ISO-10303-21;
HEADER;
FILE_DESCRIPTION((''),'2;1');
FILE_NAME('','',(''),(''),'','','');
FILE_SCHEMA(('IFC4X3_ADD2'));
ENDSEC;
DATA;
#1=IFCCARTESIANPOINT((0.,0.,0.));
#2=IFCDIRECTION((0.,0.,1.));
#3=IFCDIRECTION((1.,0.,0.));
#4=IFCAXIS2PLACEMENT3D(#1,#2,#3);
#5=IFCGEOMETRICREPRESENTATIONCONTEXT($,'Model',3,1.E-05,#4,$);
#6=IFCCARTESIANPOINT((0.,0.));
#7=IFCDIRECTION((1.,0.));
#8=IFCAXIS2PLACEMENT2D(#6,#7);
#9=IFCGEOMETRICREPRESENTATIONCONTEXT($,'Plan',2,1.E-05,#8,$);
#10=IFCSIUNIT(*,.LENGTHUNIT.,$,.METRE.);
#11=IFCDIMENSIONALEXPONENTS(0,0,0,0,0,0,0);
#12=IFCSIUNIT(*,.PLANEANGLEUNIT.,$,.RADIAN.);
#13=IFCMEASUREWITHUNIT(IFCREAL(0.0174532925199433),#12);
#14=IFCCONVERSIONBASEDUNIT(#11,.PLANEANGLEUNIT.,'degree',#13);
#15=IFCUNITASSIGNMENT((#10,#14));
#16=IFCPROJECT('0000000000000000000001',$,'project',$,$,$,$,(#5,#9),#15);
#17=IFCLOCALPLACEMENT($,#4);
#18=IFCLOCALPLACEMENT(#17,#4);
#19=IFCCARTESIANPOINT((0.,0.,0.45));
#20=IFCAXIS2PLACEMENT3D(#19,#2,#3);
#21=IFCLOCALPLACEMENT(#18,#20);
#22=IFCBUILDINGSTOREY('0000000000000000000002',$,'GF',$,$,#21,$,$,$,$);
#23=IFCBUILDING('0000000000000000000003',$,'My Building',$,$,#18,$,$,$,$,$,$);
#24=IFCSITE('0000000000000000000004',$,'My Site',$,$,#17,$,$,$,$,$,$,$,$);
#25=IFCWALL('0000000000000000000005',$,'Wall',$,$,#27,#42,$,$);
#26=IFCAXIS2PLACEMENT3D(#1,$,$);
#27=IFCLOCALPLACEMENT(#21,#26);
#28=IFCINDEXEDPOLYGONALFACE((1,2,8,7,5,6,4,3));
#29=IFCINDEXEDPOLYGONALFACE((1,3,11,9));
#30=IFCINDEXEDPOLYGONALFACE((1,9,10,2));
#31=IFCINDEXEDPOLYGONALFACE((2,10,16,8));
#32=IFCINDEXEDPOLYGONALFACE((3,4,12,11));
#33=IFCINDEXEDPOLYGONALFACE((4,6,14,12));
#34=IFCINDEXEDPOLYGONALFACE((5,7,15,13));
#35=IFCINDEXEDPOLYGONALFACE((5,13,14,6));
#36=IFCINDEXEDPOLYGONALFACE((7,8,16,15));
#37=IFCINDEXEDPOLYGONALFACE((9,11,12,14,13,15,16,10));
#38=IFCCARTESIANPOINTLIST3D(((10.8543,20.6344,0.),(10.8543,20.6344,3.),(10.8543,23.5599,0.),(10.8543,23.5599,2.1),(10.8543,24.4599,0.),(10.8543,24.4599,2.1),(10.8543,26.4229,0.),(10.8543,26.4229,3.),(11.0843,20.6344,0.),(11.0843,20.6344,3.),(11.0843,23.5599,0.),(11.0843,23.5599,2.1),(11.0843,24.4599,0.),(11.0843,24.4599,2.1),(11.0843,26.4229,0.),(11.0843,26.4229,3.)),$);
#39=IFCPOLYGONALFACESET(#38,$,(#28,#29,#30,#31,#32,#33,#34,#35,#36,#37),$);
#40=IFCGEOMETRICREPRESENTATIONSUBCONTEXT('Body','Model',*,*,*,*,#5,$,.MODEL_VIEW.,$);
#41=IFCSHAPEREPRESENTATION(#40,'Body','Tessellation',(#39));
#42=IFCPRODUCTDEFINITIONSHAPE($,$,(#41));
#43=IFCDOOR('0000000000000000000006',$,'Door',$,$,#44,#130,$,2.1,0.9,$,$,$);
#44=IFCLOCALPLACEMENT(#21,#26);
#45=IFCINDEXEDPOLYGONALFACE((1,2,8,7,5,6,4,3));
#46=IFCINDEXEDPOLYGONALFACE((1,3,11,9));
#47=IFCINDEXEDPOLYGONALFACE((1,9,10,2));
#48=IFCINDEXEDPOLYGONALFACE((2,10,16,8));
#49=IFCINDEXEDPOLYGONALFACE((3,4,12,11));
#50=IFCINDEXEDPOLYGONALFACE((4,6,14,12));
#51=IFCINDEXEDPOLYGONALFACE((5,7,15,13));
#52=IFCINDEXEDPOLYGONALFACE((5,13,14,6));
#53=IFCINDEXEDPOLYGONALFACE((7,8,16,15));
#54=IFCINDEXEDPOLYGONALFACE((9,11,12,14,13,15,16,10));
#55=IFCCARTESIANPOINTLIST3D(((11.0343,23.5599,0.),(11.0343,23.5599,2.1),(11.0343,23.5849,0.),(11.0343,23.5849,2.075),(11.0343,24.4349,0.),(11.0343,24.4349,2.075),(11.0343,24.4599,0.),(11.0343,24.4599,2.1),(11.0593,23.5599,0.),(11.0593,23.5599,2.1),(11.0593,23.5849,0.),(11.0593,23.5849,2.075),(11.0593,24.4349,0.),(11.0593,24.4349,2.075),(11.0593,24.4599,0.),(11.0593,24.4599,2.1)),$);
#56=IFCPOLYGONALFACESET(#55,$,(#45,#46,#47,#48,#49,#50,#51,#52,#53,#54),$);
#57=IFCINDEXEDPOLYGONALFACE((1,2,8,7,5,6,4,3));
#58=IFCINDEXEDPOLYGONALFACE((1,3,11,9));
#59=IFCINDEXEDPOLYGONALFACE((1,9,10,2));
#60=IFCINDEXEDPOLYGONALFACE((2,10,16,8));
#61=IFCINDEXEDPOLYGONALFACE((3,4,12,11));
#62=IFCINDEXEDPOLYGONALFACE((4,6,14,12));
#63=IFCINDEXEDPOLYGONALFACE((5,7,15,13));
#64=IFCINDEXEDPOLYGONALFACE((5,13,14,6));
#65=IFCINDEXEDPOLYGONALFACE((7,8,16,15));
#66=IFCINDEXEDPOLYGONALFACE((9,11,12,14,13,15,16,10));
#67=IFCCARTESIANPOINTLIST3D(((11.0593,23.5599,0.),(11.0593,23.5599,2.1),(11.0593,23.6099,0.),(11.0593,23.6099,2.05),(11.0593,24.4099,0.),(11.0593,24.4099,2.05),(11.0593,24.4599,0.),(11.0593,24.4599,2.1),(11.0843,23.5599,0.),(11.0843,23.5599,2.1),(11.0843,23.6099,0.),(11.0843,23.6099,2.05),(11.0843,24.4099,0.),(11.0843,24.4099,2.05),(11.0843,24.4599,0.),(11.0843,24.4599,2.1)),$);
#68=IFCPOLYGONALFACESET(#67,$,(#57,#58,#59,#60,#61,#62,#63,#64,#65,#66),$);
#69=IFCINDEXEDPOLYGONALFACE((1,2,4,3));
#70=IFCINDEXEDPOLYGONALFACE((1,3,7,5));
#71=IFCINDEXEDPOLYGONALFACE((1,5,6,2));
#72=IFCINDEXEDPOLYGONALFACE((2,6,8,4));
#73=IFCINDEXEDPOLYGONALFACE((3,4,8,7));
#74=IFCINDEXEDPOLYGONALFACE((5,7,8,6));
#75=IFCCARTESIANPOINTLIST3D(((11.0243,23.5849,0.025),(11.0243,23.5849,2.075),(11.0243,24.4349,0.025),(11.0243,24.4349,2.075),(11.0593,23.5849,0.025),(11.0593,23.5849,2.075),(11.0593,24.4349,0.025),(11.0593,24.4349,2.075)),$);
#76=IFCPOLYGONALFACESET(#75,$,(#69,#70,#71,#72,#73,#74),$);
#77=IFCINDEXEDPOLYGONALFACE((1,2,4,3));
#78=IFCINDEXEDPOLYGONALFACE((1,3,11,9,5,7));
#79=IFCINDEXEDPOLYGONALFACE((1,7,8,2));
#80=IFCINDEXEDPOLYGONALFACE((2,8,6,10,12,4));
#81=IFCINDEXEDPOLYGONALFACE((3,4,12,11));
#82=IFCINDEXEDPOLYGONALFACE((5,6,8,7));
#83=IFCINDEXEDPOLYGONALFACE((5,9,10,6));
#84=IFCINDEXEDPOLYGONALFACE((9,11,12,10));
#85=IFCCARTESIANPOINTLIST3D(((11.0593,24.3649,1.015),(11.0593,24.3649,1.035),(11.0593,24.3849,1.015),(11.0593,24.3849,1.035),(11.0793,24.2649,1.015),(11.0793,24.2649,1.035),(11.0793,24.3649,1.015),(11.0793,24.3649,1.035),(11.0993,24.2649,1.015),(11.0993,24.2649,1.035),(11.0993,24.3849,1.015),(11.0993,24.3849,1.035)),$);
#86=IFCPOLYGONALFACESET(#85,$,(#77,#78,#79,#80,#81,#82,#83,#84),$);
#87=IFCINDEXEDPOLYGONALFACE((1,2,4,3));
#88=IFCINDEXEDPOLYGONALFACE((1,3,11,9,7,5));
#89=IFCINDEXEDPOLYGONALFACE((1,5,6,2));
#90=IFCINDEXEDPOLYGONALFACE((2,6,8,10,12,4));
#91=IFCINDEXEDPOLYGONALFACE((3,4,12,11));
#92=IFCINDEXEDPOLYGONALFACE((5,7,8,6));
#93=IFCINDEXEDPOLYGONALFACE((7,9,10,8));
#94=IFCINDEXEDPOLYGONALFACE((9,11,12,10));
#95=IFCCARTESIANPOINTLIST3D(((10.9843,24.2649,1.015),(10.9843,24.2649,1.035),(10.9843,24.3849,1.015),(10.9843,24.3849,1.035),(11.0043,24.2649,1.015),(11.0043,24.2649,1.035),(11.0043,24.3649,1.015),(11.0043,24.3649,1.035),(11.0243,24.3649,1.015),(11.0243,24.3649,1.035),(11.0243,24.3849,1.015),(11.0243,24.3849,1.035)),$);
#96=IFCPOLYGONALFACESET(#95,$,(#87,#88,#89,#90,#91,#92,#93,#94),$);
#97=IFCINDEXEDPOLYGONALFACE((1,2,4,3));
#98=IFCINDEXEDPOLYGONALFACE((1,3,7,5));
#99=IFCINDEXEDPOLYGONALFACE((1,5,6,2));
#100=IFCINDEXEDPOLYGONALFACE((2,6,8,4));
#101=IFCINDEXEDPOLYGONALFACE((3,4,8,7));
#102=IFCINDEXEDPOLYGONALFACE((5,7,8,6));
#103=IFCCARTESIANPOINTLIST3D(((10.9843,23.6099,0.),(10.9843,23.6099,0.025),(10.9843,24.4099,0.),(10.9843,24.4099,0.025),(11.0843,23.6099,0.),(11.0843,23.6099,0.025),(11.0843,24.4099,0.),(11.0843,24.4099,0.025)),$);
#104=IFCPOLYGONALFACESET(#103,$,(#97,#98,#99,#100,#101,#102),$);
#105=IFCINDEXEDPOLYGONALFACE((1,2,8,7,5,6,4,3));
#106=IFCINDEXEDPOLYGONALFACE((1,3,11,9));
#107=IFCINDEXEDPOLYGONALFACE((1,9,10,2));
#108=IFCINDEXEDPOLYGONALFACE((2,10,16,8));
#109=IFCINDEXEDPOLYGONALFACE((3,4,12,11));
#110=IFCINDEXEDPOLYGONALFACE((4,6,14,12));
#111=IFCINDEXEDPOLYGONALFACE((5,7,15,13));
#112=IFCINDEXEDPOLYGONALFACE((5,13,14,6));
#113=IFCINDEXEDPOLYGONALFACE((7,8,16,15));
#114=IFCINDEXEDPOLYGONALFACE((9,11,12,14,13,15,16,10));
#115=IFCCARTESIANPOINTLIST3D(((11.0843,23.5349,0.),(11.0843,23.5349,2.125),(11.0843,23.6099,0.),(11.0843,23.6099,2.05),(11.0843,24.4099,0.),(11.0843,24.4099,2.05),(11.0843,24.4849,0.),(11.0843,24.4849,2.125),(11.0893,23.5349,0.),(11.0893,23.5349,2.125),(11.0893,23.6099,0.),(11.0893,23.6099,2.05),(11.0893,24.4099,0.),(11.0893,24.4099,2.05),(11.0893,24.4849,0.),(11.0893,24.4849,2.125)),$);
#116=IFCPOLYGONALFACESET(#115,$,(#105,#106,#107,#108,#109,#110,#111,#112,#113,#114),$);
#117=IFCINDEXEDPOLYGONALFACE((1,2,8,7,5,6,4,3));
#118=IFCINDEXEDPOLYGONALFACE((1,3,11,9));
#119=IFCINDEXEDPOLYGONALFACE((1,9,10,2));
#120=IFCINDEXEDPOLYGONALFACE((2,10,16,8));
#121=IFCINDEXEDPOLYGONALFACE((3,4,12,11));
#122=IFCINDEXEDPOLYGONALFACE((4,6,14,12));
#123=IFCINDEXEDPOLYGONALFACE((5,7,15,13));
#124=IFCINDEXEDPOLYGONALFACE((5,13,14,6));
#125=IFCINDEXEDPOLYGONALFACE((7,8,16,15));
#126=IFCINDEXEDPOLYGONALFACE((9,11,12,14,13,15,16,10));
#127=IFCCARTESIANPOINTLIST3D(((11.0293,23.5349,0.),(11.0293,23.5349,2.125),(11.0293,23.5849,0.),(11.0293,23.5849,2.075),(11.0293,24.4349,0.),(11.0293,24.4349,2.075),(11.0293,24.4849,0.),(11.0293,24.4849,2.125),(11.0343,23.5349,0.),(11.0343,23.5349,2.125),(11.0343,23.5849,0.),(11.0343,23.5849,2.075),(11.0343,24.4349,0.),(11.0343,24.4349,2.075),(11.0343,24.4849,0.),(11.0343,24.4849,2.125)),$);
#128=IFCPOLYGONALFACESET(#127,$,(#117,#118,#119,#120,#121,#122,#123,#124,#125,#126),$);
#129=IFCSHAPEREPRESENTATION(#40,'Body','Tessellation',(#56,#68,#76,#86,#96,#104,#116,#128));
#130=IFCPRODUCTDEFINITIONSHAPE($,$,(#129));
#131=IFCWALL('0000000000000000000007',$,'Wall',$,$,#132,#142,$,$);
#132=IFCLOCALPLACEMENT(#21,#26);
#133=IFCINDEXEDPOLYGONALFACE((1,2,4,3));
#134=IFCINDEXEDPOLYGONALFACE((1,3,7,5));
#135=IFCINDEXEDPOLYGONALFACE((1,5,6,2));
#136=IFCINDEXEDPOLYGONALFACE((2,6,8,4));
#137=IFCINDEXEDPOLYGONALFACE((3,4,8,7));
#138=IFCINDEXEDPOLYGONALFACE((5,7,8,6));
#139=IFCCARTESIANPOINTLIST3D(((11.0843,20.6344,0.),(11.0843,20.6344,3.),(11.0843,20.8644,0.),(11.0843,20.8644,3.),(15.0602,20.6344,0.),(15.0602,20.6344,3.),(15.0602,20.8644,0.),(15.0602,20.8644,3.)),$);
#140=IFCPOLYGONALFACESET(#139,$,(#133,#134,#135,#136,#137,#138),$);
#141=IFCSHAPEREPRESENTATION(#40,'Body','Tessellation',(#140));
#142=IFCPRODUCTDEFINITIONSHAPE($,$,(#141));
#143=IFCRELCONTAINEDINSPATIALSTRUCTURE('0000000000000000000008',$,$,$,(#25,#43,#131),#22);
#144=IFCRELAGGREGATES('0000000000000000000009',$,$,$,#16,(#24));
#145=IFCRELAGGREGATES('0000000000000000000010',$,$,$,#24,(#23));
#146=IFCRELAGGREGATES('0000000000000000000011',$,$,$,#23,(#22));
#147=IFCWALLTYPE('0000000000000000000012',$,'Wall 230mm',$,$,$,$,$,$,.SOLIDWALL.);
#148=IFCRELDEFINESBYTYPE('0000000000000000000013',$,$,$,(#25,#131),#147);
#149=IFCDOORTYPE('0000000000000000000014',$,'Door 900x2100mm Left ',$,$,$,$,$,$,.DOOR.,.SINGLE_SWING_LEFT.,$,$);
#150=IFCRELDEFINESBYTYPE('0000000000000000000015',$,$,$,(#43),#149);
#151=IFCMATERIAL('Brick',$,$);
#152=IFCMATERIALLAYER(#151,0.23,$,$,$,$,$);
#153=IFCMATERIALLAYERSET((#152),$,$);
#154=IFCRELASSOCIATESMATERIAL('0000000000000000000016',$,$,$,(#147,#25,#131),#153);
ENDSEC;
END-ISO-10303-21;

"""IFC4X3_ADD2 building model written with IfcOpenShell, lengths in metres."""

from ifc_helpers import new_model, entity, si_unit, converted_unit, frame, origin_with_axes, origin_2d_with_axis, place, context, subcontext, project, spatial, line, indexed_curve, outline, extrude, shape, source, transform, mapped, material, layer, layer_set, layer_usage, type_object, type_shapes, element, fill, save


model = new_model("IFC4X3_ADD2")

# Units and contexts
model_context = context("Model", 3, precision=1e-05, world=origin_with_axes())
plan_context = context("Plan", 2, precision=1e-05, world=origin_2d_with_axis())
body_context_1 = subcontext(model_context, "Body", "Model", "MODEL_VIEW")
body_context_2 = subcontext(plan_context, "Body", "Plan", "PLAN_VIEW")
ifc_project = project(units=[si_unit("LENGTHUNIT", "METRE"), converted_unit("PLANEANGLEUNIT", "degree", entity("IfcReal", 0.0174532925199433), si_unit("PLANEANGLEUNIT", "RADIAN"), dimensions=[0, 0, 0, 0, 0, 0, 0])], contexts=[model_context, plan_context])

# Site, building, storey
site_placement = place(None, origin_with_axes())
site = spatial("IfcSite", under=ifc_project, at=site_placement, Name="My Site")
building_placement = place(site_placement, origin_with_axes())
building = spatial("IfcBuilding", under=site, at=building_placement, Name="My Building")
storey_placement = place(building_placement, frame((0.0, 0.0, 0.45), z_axis=(0.0, 0.0, 1.0), x_axis=(1.0, 0.0, 0.0)))
storey = spatial("IfcBuildingStorey", under=building, at=storey_placement, Name="GF")

# Shared definitions
ifc_material = material(Name="Brick")
ifc_layer_1 = layer(ifc_material, 0.23)
ifc_layer_set_1 = layer_set([ifc_layer_1])
wall_type_1 = type_object("IfcWallType", Name="Wall 230mm", PredefinedType="SOLIDWALL", material=ifc_layer_set_1)

# Wall, opening, door
ifc_layer_usage_1 = layer_usage(ifc_layer_set_1, "AXIS2", "POSITIVE", 0.0)
wall_1_placement = place(storey_placement, frame((11.0843, 20.6344, 0.0), z_axis=(0.0, 0.0, 1.0), x_axis=(0.0, 1.0, 0.0)))
wall_1 = element("IfcWall", 1, at=wall_1_placement, inside=storey, type_object=wall_type_1, material=ifc_layer_usage_1, Name="Wall", context=body_context_1, shape_type="SweptSolid", body=[
    extrude(outline(indexed_curve([(0.0, 0.0), (0.0, 0.23), (5.7885, 0.23), (5.7885, 0.0), (0.0, 0.0)], self_intersect=False)), origin_with_axes(), (0.0, 0.0, 1.0), 3.0),
])
shared_shape_1 = source(origin_with_axes(), body_context_1, "Body", "SweptSolid", [
    extrude(outline(indexed_curve([(0.0, 0.0), (0.9, 0.0), (0.9, 2.1), (0.0, 2.1)], segments=[line(1, 2, 3, 4, 1)])), frame((0.0, -0.6, 0.0), z_axis=(0.0, -1.0, 0.0), x_axis=(1.0, 0.0, 0.0)), (0.0, 0.0, -1.0), 1.2),
])
opening_1_placement = place(wall_1_placement, frame((2.9255, 0.0, 0.0), z_axis=(0.0, 0.0, 1.0), x_axis=(1.0, 0.0, 0.0)))
opening_1 = element("IfcOpeningElement", 2, at=opening_1_placement, cuts=wall_1, PredefinedType="OPENING", context=body_context_1, shape_type="MappedRepresentation", body=[
    mapped(shared_shape_1, transform((0.0, 0.0, 0.0), x_axis=(1.0, 0.0, 0.0), y_axis=(0.0, 1.0, 0.0), z_axis=(0.0, 0.0, 1.0), scale=1.0)),
])
door_type_1 = type_object("IfcDoorType", Name="Door 900x2100mm Left ", OperationType="SINGLE_SWING_LEFT", PredefinedType="DOOR")
shared_shape_2 = source(origin_with_axes(), body_context_1, "Body", "SweptSolid", [
    extrude(outline(indexed_curve([(0.0, 0.0), (0.0, 2.1), (0.9, 2.1), (0.9, 0.0), (0.875, 0.0), (0.875, 2.075), (0.025, 2.075), (0.025, 0.0)], segments=[line(1, 2, 3, 4, 5, 6, 7, 8, 1)])), frame((0.0, 0.025, 0.0), z_axis=(0.0, -1.0, 0.0), x_axis=(1.0, 0.0, 0.0)), (0.0, 0.0, -1.0), 0.025),
    extrude(outline(indexed_curve([(0.0, 0.0), (0.0, 2.1), (0.9, 2.1), (0.9, 0.0), (0.85, 0.0), (0.85, 2.05), (0.05, 2.05), (0.05, 0.0)], segments=[line(1, 2, 3, 4, 5, 6, 7, 8, 1)])), frame((0.0, 0.0, 0.0), z_axis=(0.0, -1.0, 0.0), x_axis=(1.0, 0.0, 0.0)), (0.0, 0.0, -1.0), 0.025),
    extrude(outline(indexed_curve([(0.0, 0.0), (0.85, 0.0), (0.85, 0.035), (0.0, 0.035)], segments=[line(1, 2, 3, 4, 1)])), frame((0.025, 0.025, 0.025), z_axis=(0.0, 0.0, 1.0), x_axis=(1.0, 0.0, 0.0)), (0.0, 0.0, 1.0), 2.05),
    extrude(outline(indexed_curve([(0.0, 0.0), (0.0, -0.04), (-0.12, -0.04), (-0.12, -0.02), (-0.02, -0.02), (-0.02, 0.0)], segments=[line(1, 2, 3, 4, 5, 6, 1)])), frame((0.825, 0.025, 1.015), z_axis=(0.0, 0.0, 1.0), x_axis=(1.0, 0.0, 0.0)), (0.0, 0.0, 1.0), 0.02),
    extrude(outline(indexed_curve([(0.0, 0.0), (0.0, 0.04), (-0.12, 0.04), (-0.12, 0.02), (-0.02, 0.02), (-0.02, 0.0)], segments=[line(1, 2, 3, 4, 5, 6, 1)])), frame((0.825, 0.06, 1.015), z_axis=(0.0, 0.0, 1.0), x_axis=(1.0, 0.0, 0.0)), (0.0, 0.0, 1.0), 0.02),
    extrude(outline(indexed_curve([(0.0, 0.0), (0.8, 0.0), (0.8, 0.1), (0.0, 0.1)], segments=[line(1, 2, 3, 4, 1)])), frame((0.05, 0.0, 0.0), z_axis=(0.0, 0.0, 1.0), x_axis=(1.0, 0.0, 0.0)), (0.0, 0.0, 1.0), 0.025),
    extrude(outline(indexed_curve([(0.0, 0.0), (0.0, 2.125), (0.95, 2.125), (0.95, 0.0), (0.875, 0.0), (0.875, 2.05), (0.075, 2.05), (0.075, 0.0)], segments=[line(1, 2, 3, 4, 5, 6, 7, 8, 1)])), frame((-0.025, -0.005, 0.0), z_axis=(0.0, -1.0, 0.0), x_axis=(1.0, 0.0, 0.0)), (0.0, 0.0, -1.0), 0.005),
    extrude(outline(indexed_curve([(0.0, 0.0), (0.0, 2.125), (0.95, 2.125), (0.95, 0.0), (0.9, 0.0), (0.9, 2.075), (0.05, 2.075), (0.05, 0.0)], segments=[line(1, 2, 3, 4, 5, 6, 7, 8, 1)])), frame((-0.025, 0.05, 0.0), z_axis=(0.0, -1.0, 0.0), x_axis=(1.0, 0.0, 0.0)), (0.0, 0.0, -1.0), 0.005),
])
shared_shape_3 = source(origin_with_axes(), body_context_2, "Body", "Curve2D", [
    entity("IfcIndexedPolyCurve", entity("IfcCartesianPointList2D", [[0.0, 0.0], [0.0, 0.05], [0.025, 0.05], [0.025, 0.025], [0.05, 0.025], [0.05, 0.0]]), [entity("IfcLineIndex", [1, 2, 3, 4, 5, 6, 1])]),
    entity("IfcIndexedPolyCurve", entity("IfcCartesianPointList2D", [[0.9, 0.0], [0.9, 0.05], [0.875, 0.05], [0.875, 0.025], [0.85, 0.025], [0.85, 0.0]]), [entity("IfcLineIndex", [1, 2, 3, 4, 5, 6, 1])]),
    entity("IfcTrimmedCurve", entity("IfcEllipse", entity("IfcAxis2Placement2D", entity("IfcCartesianPoint", [0.06, 0.05]), entity("IfcDirection", [1.0, 0.0])), 0.815, 0.85), [entity("IfcCartesianPoint", [0.875, 0.05])], [entity("IfcCartesianPoint", [0.06, 0.9])], True, "CARTESIAN"),
    entity("IfcIndexedPolyCurve", entity("IfcCartesianPointList2D", [[0.025, 0.05], [0.06, 0.05], [0.06, 0.9], [0.025, 0.9]]), [entity("IfcLineIndex", [1, 2, 3, 4, 1])]),
])
type_shapes(door_type_1, [shared_shape_2, shared_shape_3])
door_1_placement = place(opening_1_placement, origin_with_axes())
door_1 = element("IfcDoor", 3, at=door_1_placement, inside=storey, type_object=door_type_1, Name="Door", OverallHeight=2.1, OverallWidth=0.9, shapes=[
    shape(body_context_1, "Body", "MappedRepresentation", [mapped(shared_shape_2, transform((0.0, 0.0, 0.0), x_axis=(1.0, 0.0, 0.0), y_axis=(0.0, 1.0, 0.0), z_axis=(0.0, 0.0, 1.0), scale=1.0))]),
    shape(body_context_2, "Body", "MappedRepresentation", [mapped(shared_shape_3, transform((0.0, 0.0, 0.0), x_axis=(1.0, 0.0, 0.0), y_axis=(0.0, 1.0, 0.0), z_axis=(0.0, 0.0, 1.0), scale=1.0))]),
])
fill(opening_1, door_1)

# Wall
ifc_layer_usage_2 = layer_usage(ifc_layer_set_1, "AXIS2", "POSITIVE", 0.0)
wall_2_placement = place(storey_placement, frame((11.0843, 20.6344, 0.0), z_axis=(0.0, 0.0, 1.0), x_axis=(1.0, 0.0, 0.0)))
element("IfcWall", 4, at=wall_2_placement, inside=storey, type_object=wall_type_1, material=ifc_layer_usage_2, Name="Wall", context=body_context_1, shape_type="SweptSolid", body=[
    extrude(outline(indexed_curve([(0.0, 0.0), (0.0, 0.23), (3.9759, 0.23), (3.9759, 0.0), (0.0, 0.0)], self_intersect=False)), origin_with_axes(), (0.0, 0.0, 1.0), 3.0),
])

save(model, "model.ifc")
